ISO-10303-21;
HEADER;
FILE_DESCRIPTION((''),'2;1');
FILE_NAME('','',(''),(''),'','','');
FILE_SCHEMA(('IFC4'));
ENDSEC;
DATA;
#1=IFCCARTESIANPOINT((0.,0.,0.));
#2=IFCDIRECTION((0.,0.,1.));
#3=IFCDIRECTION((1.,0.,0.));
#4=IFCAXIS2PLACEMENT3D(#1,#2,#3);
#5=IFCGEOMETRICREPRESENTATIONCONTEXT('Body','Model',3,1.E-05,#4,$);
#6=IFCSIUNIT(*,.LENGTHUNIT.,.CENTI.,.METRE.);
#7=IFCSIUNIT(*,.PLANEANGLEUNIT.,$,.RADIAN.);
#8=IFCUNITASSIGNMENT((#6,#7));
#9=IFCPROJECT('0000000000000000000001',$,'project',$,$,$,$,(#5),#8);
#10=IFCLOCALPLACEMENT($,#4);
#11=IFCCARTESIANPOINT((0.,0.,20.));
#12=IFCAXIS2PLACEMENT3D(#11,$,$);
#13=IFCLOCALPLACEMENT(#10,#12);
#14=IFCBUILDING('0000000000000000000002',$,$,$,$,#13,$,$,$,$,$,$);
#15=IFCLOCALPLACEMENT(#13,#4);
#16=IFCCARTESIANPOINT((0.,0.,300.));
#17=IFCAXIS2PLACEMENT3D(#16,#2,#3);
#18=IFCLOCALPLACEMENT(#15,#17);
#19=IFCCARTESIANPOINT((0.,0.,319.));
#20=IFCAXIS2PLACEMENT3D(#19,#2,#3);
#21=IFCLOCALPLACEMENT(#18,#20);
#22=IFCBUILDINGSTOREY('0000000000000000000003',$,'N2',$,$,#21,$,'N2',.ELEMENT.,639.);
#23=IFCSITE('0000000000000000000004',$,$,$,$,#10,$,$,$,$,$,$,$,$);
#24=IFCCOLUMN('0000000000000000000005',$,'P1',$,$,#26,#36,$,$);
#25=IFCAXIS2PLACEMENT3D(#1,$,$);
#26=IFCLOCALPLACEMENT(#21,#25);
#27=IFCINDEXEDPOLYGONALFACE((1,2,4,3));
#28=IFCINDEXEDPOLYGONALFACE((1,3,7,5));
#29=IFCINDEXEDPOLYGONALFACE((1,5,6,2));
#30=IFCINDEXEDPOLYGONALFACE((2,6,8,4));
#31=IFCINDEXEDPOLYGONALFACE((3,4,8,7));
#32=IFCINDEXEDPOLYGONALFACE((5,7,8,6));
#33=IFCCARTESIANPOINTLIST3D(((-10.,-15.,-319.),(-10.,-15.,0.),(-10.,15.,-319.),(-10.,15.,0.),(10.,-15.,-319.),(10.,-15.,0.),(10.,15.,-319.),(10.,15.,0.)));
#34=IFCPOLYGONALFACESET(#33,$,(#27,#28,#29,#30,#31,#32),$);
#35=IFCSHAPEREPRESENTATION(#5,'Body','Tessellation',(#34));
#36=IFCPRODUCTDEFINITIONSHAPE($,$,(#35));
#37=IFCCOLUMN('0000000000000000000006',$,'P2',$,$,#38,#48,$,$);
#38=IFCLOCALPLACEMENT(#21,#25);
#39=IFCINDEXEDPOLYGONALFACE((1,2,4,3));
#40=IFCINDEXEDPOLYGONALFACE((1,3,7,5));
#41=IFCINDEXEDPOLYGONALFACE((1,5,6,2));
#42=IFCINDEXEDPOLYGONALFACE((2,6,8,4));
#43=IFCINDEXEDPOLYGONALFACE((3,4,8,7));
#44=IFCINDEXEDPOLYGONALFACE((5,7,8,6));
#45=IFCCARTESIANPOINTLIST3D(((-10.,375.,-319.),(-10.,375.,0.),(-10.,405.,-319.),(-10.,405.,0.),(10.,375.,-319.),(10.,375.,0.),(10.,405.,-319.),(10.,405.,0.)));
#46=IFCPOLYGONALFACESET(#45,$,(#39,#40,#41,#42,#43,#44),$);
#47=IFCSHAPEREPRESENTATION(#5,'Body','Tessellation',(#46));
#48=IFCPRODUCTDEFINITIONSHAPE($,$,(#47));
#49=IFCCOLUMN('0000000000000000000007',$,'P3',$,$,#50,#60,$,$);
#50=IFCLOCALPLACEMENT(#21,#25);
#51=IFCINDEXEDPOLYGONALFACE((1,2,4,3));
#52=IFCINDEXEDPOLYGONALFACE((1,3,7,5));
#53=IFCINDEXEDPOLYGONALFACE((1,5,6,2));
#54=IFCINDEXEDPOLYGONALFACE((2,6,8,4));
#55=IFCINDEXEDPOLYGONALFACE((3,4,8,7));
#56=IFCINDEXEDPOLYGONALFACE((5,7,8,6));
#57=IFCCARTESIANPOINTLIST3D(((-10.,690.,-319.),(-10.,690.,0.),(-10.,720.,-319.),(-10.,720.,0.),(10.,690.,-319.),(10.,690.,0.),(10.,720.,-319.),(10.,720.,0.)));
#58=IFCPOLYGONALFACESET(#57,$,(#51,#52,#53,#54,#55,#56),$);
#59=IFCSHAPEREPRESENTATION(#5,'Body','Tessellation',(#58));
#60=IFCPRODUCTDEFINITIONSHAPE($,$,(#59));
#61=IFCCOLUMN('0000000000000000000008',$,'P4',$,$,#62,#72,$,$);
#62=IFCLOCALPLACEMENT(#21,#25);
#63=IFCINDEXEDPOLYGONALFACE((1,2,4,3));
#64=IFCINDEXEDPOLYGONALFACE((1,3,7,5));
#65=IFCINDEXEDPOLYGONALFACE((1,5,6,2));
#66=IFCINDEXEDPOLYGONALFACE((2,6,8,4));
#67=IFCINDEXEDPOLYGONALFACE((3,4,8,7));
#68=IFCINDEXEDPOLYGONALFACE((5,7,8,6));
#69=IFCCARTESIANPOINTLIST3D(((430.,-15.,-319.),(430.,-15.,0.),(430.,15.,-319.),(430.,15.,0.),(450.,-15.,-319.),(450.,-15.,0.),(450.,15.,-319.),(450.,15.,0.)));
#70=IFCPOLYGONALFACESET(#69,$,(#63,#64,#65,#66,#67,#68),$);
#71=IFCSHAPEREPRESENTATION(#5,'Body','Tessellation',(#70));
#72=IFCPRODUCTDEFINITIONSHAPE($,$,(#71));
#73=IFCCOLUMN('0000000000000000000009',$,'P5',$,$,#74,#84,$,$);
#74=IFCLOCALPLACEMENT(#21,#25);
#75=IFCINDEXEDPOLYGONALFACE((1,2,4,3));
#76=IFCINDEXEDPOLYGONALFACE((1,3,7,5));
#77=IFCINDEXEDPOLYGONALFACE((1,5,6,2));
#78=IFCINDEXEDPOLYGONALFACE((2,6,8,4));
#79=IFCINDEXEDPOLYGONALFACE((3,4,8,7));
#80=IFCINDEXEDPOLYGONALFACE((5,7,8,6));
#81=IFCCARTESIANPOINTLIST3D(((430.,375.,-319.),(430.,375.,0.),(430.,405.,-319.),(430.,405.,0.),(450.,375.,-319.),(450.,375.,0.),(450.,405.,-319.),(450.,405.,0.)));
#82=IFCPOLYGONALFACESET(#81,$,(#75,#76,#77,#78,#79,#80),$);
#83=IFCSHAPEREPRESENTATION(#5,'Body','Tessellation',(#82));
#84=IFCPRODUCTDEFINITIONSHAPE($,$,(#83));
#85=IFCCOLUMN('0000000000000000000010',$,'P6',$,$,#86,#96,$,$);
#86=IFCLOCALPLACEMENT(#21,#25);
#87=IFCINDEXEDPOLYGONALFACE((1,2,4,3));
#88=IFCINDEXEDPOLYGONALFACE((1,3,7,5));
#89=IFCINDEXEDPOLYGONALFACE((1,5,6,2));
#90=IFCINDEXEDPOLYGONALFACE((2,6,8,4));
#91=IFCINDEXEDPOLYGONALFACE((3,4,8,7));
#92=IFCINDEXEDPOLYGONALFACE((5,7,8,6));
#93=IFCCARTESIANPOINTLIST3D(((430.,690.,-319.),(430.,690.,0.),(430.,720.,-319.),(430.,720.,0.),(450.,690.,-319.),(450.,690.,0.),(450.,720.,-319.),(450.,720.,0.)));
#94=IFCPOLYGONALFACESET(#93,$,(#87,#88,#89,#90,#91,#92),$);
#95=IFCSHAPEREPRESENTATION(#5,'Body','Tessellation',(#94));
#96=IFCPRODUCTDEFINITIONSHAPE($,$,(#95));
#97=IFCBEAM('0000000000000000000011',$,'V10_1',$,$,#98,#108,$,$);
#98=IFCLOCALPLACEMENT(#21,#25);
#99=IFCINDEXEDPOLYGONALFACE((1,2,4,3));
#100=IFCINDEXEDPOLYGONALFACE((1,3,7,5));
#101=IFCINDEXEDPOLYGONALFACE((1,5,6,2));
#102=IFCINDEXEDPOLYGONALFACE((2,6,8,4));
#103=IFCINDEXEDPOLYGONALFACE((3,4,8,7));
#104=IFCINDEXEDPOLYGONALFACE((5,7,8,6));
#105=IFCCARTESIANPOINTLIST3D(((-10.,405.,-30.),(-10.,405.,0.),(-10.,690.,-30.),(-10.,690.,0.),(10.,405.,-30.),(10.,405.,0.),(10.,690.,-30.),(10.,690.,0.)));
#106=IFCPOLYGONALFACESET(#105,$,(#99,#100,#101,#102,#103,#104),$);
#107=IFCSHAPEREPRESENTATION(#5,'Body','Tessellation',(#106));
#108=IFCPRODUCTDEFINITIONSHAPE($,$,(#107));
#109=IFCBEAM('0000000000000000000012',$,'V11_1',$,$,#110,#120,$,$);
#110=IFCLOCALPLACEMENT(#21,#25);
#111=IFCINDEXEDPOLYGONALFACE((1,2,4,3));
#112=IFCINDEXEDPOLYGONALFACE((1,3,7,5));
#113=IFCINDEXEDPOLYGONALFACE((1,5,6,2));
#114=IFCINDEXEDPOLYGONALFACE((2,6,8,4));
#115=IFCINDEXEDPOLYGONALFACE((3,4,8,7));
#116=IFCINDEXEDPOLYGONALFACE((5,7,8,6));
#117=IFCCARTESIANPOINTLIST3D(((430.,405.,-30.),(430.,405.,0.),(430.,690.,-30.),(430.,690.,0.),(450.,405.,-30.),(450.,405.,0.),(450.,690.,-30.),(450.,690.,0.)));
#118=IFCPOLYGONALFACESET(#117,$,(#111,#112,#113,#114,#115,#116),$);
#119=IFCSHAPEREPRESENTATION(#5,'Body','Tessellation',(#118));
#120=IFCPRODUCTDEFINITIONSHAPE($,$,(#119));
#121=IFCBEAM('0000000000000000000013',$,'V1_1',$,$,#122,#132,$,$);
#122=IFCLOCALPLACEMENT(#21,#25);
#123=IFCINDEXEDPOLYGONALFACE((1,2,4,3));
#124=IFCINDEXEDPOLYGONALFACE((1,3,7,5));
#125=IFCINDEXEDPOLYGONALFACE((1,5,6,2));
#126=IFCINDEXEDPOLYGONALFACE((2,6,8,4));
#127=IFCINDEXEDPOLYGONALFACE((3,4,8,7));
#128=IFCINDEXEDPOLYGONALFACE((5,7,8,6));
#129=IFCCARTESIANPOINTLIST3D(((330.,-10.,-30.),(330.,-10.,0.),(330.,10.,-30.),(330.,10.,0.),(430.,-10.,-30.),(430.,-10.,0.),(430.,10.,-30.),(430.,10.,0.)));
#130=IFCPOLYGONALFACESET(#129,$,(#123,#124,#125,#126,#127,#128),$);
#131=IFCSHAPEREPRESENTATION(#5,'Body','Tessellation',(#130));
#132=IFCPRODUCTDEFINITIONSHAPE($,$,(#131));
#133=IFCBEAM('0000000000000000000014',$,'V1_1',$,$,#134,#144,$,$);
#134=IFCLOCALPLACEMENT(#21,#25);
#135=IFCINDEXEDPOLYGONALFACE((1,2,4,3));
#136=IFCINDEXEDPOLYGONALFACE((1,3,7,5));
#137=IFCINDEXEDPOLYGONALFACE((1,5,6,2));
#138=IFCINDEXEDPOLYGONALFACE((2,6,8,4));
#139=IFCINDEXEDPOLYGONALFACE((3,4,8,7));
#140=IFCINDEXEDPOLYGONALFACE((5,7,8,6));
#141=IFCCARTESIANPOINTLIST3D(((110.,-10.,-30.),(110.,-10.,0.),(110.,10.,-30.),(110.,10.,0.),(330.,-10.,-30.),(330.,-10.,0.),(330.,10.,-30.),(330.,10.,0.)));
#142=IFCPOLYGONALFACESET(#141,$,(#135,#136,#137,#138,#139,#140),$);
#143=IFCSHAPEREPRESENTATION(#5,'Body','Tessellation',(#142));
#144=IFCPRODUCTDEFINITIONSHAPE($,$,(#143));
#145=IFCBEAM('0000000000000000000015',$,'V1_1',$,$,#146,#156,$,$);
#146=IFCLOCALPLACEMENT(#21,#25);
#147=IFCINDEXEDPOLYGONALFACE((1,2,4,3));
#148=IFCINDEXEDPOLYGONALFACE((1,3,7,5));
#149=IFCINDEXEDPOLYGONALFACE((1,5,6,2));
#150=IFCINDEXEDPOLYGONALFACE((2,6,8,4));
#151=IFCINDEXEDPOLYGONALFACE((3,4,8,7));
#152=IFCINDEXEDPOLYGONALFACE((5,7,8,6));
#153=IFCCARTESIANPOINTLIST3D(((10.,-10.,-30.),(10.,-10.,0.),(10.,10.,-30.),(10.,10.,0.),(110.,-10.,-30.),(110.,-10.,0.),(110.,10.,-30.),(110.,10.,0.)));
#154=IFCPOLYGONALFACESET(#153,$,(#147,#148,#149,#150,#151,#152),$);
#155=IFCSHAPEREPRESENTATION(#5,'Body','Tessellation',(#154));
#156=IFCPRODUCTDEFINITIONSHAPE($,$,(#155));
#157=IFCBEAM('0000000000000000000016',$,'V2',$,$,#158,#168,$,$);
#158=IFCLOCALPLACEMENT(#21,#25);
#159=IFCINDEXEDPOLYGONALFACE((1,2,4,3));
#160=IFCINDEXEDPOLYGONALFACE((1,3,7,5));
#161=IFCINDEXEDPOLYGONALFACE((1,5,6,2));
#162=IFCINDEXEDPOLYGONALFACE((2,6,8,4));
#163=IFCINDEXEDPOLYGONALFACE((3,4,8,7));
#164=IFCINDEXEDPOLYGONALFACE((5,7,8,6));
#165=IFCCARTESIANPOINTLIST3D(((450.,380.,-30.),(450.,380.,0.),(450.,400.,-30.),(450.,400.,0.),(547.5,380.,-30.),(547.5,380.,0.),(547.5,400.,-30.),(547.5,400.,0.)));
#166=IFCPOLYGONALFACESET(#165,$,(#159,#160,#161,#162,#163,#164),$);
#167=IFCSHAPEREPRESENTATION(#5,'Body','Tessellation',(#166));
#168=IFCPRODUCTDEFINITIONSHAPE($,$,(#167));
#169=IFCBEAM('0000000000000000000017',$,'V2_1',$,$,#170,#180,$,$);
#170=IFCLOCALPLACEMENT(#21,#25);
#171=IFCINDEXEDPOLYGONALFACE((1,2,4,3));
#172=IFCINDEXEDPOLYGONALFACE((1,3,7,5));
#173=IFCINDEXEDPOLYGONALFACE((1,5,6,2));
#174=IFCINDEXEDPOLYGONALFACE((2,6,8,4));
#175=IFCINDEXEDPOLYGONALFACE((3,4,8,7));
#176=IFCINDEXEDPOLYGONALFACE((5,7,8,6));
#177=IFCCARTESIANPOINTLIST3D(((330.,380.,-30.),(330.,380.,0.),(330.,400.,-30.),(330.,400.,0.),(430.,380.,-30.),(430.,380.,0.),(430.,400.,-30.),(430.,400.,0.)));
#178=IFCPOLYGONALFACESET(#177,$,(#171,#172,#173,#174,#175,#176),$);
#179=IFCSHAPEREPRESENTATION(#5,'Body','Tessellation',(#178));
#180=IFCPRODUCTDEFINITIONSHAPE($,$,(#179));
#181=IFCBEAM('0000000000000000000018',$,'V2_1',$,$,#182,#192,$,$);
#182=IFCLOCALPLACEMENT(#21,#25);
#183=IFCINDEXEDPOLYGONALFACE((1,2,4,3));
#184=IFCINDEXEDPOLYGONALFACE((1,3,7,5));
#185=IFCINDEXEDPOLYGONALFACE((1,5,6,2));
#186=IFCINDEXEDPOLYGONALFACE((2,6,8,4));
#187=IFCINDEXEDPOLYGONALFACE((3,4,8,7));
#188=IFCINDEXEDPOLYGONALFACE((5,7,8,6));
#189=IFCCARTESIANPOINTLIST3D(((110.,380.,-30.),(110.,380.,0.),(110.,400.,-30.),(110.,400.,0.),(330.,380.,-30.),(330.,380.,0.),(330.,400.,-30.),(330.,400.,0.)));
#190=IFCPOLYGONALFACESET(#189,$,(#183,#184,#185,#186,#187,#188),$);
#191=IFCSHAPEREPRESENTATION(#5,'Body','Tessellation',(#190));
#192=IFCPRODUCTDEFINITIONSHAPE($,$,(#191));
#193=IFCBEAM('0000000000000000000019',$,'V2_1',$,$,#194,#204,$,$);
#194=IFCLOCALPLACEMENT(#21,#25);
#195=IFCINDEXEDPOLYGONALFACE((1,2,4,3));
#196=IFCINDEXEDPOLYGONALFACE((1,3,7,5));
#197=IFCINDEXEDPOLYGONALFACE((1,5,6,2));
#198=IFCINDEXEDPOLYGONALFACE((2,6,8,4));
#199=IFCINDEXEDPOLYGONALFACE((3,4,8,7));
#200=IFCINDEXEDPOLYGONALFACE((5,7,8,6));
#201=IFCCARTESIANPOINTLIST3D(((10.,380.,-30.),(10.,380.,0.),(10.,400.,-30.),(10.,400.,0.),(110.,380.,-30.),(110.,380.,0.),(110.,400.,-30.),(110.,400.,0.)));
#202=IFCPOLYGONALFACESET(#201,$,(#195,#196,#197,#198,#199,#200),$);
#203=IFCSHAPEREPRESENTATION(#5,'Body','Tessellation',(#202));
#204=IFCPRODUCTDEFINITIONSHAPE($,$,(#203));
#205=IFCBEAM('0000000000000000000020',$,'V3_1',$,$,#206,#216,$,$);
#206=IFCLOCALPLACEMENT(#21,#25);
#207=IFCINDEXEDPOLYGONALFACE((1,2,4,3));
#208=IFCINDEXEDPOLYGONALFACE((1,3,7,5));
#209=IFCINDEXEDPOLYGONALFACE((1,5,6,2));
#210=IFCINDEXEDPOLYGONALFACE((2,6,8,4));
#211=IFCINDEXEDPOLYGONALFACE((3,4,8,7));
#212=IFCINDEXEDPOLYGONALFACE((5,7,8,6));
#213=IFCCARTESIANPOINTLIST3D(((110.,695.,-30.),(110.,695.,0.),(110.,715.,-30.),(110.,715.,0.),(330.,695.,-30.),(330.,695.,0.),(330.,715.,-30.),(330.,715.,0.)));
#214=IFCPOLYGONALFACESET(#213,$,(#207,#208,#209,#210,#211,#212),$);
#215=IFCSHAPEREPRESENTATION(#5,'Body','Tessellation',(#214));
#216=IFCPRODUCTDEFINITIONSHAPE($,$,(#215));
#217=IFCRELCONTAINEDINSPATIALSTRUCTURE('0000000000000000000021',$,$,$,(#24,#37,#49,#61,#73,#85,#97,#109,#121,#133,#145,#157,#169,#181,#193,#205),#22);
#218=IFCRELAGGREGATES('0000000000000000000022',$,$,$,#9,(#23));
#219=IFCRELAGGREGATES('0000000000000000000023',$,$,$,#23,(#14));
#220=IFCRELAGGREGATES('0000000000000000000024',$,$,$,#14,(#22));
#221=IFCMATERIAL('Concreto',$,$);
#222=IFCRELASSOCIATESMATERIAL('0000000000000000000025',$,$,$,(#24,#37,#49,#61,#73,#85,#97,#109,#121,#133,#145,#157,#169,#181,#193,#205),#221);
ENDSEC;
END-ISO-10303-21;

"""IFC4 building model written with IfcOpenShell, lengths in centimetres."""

from ifc_helpers import new_model, si_unit, frame, origin_with_axes, origin_2d_with_axis, place, context, project, spatial, rectangle, extrude, material, element, save


model = new_model("IFC4")

# Units and contexts
model_context = context("Model", 3, precision=1e-05, world=origin_with_axes(), identifier="Body")
ifc_project = project(units=[si_unit("LENGTHUNIT", "METRE", prefix="CENTI"), si_unit("PLANEANGLEUNIT", "RADIAN")], contexts=[model_context])

# Site, building, storey
site_placement = place(None, origin_with_axes())
site = spatial("IfcSite", under=ifc_project, at=site_placement)
building_placement = place(site_placement, frame((0.0, 0.0, 20.0)))
building = spatial("IfcBuilding", under=site, at=building_placement)
placement_1 = place(building_placement, origin_with_axes())
placement_2 = place(placement_1, frame((0.0, 0.0, 300.0), z_axis=(0.0, 0.0, 1.0), x_axis=(1.0, 0.0, 0.0)))
storey_placement = place(placement_2, frame((0.0, 0.0, 319.0), z_axis=(0.0, 0.0, 1.0), x_axis=(1.0, 0.0, 0.0)))
storey = spatial("IfcBuildingStorey", under=building, at=storey_placement, Name="N2", LongName="N2", CompositionType="ELEMENT", Elevation=639.0)

# Columns
ifc_material = material(Name="Concreto")
for number, where, z_axis, x_axis, name in (
    (1, (0.0, 0.0, 0.0), (0.0, 0.0, 1.0), (1.0, 0.0, 0.0), "P1"),
    (2, (0.0, 390.0, 0.0), (0.0, 0.0, 1.0), (1.0, 0.0, 0.0), "P2"),
    (3, (0.0, 705.0, 0.0), (0.0, 0.0, 1.0), (1.0, 0.0, 0.0), "P3"),
    (4, (440.0, 0.0, 0.0), (0.0, 0.0, 1.0), (1.0, 0.0, 0.0), "P4"),
    (5, (440.0, 390.0, 0.0), (0.0, 0.0, 1.0), (1.0, 0.0, 0.0), "P5"),
    (6, (440.0, 705.0, 0.0), (0.0, 0.0, 1.0), (1.0, 0.0, 0.0), "P6"),
):
    element("IfcColumn", number, at=place(storey_placement, frame(where, z_axis=z_axis, x_axis=x_axis)), inside=storey, material=ifc_material, Name=name, context=model_context, shape_type="SolidModel", body=[
        extrude(rectangle(XDim=20.0, YDim=30.0, at=origin_2d_with_axis()), origin_with_axes(), (0.0, 0.0, -1.0), 319.0),
    ])

# Beams
beam_1_placement = place(storey_placement, frame((0.0, 547.5, 0.0), z_axis=(0.0, 0.0, 1.0), x_axis=(1.0, 0.0, 0.0)))
element("IfcBeam", 7, at=beam_1_placement, inside=storey, material=ifc_material, Name="V10_1", context=model_context, shape_type="SolidModel", body=[
    extrude(rectangle(XDim=20.0, YDim=30.0, at=origin_2d_with_axis()), frame((0.0, -142.5, -15.0), z_axis=(0.0, 1.0, 0.0), x_axis=(-1.0, 0.0, 0.0)), (0.0, 0.0, 1.0), 285.0),
])
beam_2_placement = place(storey_placement, frame((440.0, 547.5, 0.0), z_axis=(0.0, 0.0, 1.0), x_axis=(1.0, 0.0, 0.0)))
element("IfcBeam", 8, at=beam_2_placement, inside=storey, material=ifc_material, Name="V11_1", context=model_context, shape_type="SolidModel", body=[
    extrude(rectangle(XDim=20.0, YDim=30.0, at=origin_2d_with_axis()), frame((0.0, -142.5, -15.0), z_axis=(0.0, 1.0, 0.0), x_axis=(1.0, 0.0, 0.0)), (0.0, 0.0, 1.0), 285.0),
])
beam_3_placement = place(storey_placement, frame((380.0, 0.0, 0.0), z_axis=(0.0, 0.0, 1.0), x_axis=(1.0, 0.0, 0.0)))
element("IfcBeam", 9, at=beam_3_placement, inside=storey, material=ifc_material, Name="V1_1", context=model_context, shape_type="SolidModel", body=[
    extrude(rectangle(XDim=20.0, YDim=30.0, at=origin_2d_with_axis()), frame((-50.0, 0.0, -15.0), z_axis=(1.0, 0.0, 0.0), x_axis=(0.0, 1.0, 0.0)), (0.0, 0.0, 1.0), 100.0),
])
beam_4_placement = place(storey_placement, frame((220.0, 0.0, 0.0), z_axis=(0.0, 0.0, 1.0), x_axis=(1.0, 0.0, 0.0)))
element("IfcBeam", 10, at=beam_4_placement, inside=storey, material=ifc_material, Name="V1_1", context=model_context, shape_type="SolidModel", body=[
    extrude(rectangle(XDim=20.0, YDim=30.0, at=origin_2d_with_axis()), frame((-110.0, 0.0, -15.0), z_axis=(1.0, 0.0, 0.0), x_axis=(0.0, 1.0, 0.0)), (0.0, 0.0, 1.0), 220.0),
])
beam_5_placement = place(storey_placement, frame((60.0, 0.0, 0.0), z_axis=(0.0, 0.0, 1.0), x_axis=(1.0, 0.0, 0.0)))
element("IfcBeam", 11, at=beam_5_placement, inside=storey, material=ifc_material, Name="V1_1", context=model_context, shape_type="SolidModel", body=[
    extrude(rectangle(XDim=20.0, YDim=30.0, at=origin_2d_with_axis()), frame((-50.0, 0.0, -15.0), z_axis=(1.0, 0.0, 0.0), x_axis=(0.0, 1.0, 0.0)), (0.0, 0.0, 1.0), 100.0),
])
beam_6_placement = place(storey_placement, frame((498.75, 390.0, 0.0), z_axis=(0.0, 0.0, 1.0), x_axis=(1.0, 0.0, 0.0)))
element("IfcBeam", 12, at=beam_6_placement, inside=storey, material=ifc_material, Name="V2", context=model_context, shape_type="SolidModel", body=[
    extrude(rectangle(XDim=20.0, YDim=30.0, at=origin_2d_with_axis()), frame((-48.75, 0.0, -15.0), z_axis=(1.0, 0.0, 0.0), x_axis=(0.0, 1.0, 0.0)), (0.0, 0.0, 1.0), 97.5),
])
beam_7_placement = place(storey_placement, frame((380.0, 390.0, 0.0), z_axis=(0.0, 0.0, 1.0), x_axis=(1.0, 0.0, 0.0)))
element("IfcBeam", 13, at=beam_7_placement, inside=storey, material=ifc_material, Name="V2_1", context=model_context, shape_type="SolidModel", body=[
    extrude(rectangle(XDim=20.0, YDim=30.0, at=origin_2d_with_axis()), frame((-50.0, 0.0, -15.0), z_axis=(1.0, 0.0, 0.0), x_axis=(0.0, 1.0, 0.0)), (0.0, 0.0, 1.0), 100.0),
])
beam_8_placement = place(storey_placement, frame((220.0, 390.0, 0.0), z_axis=(0.0, 0.0, 1.0), x_axis=(1.0, 0.0, 0.0)))
element("IfcBeam", 14, at=beam_8_placement, inside=storey, material=ifc_material, Name="V2_1", context=model_context, shape_type="SolidModel", body=[
    extrude(rectangle(XDim=20.0, YDim=30.0, at=origin_2d_with_axis()), frame((-110.0, 0.0, -15.0), z_axis=(1.0, 0.0, 0.0), x_axis=(0.0, 1.0, 0.0)), (0.0, 0.0, 1.0), 220.0),
])
beam_9_placement = place(storey_placement, frame((60.0, 390.0, 0.0), z_axis=(0.0, 0.0, 1.0), x_axis=(1.0, 0.0, 0.0)))
element("IfcBeam", 15, at=beam_9_placement, inside=storey, material=ifc_material, Name="V2_1", context=model_context, shape_type="SolidModel", body=[
    extrude(rectangle(XDim=20.0, YDim=30.0, at=origin_2d_with_axis()), frame((-50.0, 0.0, -15.0), z_axis=(1.0, 0.0, 0.0), x_axis=(0.0, 1.0, 0.0)), (0.0, 0.0, 1.0), 100.0),
])
beam_10_placement = place(storey_placement, frame((220.0, 705.0, 0.0), z_axis=(0.0, 0.0, 1.0), x_axis=(1.0, 0.0, 0.0)))
element("IfcBeam", 16, at=beam_10_placement, inside=storey, material=ifc_material, Name="V3_1", context=model_context, shape_type="SolidModel", body=[
    extrude(rectangle(XDim=20.0, YDim=30.0, at=origin_2d_with_axis()), frame((-110.0, 0.0, -15.0), z_axis=(1.0, 0.0, 0.0), x_axis=(0.0, 1.0, 0.0)), (0.0, 0.0, 1.0), 220.0),
])

save(model, "model.ifc")
